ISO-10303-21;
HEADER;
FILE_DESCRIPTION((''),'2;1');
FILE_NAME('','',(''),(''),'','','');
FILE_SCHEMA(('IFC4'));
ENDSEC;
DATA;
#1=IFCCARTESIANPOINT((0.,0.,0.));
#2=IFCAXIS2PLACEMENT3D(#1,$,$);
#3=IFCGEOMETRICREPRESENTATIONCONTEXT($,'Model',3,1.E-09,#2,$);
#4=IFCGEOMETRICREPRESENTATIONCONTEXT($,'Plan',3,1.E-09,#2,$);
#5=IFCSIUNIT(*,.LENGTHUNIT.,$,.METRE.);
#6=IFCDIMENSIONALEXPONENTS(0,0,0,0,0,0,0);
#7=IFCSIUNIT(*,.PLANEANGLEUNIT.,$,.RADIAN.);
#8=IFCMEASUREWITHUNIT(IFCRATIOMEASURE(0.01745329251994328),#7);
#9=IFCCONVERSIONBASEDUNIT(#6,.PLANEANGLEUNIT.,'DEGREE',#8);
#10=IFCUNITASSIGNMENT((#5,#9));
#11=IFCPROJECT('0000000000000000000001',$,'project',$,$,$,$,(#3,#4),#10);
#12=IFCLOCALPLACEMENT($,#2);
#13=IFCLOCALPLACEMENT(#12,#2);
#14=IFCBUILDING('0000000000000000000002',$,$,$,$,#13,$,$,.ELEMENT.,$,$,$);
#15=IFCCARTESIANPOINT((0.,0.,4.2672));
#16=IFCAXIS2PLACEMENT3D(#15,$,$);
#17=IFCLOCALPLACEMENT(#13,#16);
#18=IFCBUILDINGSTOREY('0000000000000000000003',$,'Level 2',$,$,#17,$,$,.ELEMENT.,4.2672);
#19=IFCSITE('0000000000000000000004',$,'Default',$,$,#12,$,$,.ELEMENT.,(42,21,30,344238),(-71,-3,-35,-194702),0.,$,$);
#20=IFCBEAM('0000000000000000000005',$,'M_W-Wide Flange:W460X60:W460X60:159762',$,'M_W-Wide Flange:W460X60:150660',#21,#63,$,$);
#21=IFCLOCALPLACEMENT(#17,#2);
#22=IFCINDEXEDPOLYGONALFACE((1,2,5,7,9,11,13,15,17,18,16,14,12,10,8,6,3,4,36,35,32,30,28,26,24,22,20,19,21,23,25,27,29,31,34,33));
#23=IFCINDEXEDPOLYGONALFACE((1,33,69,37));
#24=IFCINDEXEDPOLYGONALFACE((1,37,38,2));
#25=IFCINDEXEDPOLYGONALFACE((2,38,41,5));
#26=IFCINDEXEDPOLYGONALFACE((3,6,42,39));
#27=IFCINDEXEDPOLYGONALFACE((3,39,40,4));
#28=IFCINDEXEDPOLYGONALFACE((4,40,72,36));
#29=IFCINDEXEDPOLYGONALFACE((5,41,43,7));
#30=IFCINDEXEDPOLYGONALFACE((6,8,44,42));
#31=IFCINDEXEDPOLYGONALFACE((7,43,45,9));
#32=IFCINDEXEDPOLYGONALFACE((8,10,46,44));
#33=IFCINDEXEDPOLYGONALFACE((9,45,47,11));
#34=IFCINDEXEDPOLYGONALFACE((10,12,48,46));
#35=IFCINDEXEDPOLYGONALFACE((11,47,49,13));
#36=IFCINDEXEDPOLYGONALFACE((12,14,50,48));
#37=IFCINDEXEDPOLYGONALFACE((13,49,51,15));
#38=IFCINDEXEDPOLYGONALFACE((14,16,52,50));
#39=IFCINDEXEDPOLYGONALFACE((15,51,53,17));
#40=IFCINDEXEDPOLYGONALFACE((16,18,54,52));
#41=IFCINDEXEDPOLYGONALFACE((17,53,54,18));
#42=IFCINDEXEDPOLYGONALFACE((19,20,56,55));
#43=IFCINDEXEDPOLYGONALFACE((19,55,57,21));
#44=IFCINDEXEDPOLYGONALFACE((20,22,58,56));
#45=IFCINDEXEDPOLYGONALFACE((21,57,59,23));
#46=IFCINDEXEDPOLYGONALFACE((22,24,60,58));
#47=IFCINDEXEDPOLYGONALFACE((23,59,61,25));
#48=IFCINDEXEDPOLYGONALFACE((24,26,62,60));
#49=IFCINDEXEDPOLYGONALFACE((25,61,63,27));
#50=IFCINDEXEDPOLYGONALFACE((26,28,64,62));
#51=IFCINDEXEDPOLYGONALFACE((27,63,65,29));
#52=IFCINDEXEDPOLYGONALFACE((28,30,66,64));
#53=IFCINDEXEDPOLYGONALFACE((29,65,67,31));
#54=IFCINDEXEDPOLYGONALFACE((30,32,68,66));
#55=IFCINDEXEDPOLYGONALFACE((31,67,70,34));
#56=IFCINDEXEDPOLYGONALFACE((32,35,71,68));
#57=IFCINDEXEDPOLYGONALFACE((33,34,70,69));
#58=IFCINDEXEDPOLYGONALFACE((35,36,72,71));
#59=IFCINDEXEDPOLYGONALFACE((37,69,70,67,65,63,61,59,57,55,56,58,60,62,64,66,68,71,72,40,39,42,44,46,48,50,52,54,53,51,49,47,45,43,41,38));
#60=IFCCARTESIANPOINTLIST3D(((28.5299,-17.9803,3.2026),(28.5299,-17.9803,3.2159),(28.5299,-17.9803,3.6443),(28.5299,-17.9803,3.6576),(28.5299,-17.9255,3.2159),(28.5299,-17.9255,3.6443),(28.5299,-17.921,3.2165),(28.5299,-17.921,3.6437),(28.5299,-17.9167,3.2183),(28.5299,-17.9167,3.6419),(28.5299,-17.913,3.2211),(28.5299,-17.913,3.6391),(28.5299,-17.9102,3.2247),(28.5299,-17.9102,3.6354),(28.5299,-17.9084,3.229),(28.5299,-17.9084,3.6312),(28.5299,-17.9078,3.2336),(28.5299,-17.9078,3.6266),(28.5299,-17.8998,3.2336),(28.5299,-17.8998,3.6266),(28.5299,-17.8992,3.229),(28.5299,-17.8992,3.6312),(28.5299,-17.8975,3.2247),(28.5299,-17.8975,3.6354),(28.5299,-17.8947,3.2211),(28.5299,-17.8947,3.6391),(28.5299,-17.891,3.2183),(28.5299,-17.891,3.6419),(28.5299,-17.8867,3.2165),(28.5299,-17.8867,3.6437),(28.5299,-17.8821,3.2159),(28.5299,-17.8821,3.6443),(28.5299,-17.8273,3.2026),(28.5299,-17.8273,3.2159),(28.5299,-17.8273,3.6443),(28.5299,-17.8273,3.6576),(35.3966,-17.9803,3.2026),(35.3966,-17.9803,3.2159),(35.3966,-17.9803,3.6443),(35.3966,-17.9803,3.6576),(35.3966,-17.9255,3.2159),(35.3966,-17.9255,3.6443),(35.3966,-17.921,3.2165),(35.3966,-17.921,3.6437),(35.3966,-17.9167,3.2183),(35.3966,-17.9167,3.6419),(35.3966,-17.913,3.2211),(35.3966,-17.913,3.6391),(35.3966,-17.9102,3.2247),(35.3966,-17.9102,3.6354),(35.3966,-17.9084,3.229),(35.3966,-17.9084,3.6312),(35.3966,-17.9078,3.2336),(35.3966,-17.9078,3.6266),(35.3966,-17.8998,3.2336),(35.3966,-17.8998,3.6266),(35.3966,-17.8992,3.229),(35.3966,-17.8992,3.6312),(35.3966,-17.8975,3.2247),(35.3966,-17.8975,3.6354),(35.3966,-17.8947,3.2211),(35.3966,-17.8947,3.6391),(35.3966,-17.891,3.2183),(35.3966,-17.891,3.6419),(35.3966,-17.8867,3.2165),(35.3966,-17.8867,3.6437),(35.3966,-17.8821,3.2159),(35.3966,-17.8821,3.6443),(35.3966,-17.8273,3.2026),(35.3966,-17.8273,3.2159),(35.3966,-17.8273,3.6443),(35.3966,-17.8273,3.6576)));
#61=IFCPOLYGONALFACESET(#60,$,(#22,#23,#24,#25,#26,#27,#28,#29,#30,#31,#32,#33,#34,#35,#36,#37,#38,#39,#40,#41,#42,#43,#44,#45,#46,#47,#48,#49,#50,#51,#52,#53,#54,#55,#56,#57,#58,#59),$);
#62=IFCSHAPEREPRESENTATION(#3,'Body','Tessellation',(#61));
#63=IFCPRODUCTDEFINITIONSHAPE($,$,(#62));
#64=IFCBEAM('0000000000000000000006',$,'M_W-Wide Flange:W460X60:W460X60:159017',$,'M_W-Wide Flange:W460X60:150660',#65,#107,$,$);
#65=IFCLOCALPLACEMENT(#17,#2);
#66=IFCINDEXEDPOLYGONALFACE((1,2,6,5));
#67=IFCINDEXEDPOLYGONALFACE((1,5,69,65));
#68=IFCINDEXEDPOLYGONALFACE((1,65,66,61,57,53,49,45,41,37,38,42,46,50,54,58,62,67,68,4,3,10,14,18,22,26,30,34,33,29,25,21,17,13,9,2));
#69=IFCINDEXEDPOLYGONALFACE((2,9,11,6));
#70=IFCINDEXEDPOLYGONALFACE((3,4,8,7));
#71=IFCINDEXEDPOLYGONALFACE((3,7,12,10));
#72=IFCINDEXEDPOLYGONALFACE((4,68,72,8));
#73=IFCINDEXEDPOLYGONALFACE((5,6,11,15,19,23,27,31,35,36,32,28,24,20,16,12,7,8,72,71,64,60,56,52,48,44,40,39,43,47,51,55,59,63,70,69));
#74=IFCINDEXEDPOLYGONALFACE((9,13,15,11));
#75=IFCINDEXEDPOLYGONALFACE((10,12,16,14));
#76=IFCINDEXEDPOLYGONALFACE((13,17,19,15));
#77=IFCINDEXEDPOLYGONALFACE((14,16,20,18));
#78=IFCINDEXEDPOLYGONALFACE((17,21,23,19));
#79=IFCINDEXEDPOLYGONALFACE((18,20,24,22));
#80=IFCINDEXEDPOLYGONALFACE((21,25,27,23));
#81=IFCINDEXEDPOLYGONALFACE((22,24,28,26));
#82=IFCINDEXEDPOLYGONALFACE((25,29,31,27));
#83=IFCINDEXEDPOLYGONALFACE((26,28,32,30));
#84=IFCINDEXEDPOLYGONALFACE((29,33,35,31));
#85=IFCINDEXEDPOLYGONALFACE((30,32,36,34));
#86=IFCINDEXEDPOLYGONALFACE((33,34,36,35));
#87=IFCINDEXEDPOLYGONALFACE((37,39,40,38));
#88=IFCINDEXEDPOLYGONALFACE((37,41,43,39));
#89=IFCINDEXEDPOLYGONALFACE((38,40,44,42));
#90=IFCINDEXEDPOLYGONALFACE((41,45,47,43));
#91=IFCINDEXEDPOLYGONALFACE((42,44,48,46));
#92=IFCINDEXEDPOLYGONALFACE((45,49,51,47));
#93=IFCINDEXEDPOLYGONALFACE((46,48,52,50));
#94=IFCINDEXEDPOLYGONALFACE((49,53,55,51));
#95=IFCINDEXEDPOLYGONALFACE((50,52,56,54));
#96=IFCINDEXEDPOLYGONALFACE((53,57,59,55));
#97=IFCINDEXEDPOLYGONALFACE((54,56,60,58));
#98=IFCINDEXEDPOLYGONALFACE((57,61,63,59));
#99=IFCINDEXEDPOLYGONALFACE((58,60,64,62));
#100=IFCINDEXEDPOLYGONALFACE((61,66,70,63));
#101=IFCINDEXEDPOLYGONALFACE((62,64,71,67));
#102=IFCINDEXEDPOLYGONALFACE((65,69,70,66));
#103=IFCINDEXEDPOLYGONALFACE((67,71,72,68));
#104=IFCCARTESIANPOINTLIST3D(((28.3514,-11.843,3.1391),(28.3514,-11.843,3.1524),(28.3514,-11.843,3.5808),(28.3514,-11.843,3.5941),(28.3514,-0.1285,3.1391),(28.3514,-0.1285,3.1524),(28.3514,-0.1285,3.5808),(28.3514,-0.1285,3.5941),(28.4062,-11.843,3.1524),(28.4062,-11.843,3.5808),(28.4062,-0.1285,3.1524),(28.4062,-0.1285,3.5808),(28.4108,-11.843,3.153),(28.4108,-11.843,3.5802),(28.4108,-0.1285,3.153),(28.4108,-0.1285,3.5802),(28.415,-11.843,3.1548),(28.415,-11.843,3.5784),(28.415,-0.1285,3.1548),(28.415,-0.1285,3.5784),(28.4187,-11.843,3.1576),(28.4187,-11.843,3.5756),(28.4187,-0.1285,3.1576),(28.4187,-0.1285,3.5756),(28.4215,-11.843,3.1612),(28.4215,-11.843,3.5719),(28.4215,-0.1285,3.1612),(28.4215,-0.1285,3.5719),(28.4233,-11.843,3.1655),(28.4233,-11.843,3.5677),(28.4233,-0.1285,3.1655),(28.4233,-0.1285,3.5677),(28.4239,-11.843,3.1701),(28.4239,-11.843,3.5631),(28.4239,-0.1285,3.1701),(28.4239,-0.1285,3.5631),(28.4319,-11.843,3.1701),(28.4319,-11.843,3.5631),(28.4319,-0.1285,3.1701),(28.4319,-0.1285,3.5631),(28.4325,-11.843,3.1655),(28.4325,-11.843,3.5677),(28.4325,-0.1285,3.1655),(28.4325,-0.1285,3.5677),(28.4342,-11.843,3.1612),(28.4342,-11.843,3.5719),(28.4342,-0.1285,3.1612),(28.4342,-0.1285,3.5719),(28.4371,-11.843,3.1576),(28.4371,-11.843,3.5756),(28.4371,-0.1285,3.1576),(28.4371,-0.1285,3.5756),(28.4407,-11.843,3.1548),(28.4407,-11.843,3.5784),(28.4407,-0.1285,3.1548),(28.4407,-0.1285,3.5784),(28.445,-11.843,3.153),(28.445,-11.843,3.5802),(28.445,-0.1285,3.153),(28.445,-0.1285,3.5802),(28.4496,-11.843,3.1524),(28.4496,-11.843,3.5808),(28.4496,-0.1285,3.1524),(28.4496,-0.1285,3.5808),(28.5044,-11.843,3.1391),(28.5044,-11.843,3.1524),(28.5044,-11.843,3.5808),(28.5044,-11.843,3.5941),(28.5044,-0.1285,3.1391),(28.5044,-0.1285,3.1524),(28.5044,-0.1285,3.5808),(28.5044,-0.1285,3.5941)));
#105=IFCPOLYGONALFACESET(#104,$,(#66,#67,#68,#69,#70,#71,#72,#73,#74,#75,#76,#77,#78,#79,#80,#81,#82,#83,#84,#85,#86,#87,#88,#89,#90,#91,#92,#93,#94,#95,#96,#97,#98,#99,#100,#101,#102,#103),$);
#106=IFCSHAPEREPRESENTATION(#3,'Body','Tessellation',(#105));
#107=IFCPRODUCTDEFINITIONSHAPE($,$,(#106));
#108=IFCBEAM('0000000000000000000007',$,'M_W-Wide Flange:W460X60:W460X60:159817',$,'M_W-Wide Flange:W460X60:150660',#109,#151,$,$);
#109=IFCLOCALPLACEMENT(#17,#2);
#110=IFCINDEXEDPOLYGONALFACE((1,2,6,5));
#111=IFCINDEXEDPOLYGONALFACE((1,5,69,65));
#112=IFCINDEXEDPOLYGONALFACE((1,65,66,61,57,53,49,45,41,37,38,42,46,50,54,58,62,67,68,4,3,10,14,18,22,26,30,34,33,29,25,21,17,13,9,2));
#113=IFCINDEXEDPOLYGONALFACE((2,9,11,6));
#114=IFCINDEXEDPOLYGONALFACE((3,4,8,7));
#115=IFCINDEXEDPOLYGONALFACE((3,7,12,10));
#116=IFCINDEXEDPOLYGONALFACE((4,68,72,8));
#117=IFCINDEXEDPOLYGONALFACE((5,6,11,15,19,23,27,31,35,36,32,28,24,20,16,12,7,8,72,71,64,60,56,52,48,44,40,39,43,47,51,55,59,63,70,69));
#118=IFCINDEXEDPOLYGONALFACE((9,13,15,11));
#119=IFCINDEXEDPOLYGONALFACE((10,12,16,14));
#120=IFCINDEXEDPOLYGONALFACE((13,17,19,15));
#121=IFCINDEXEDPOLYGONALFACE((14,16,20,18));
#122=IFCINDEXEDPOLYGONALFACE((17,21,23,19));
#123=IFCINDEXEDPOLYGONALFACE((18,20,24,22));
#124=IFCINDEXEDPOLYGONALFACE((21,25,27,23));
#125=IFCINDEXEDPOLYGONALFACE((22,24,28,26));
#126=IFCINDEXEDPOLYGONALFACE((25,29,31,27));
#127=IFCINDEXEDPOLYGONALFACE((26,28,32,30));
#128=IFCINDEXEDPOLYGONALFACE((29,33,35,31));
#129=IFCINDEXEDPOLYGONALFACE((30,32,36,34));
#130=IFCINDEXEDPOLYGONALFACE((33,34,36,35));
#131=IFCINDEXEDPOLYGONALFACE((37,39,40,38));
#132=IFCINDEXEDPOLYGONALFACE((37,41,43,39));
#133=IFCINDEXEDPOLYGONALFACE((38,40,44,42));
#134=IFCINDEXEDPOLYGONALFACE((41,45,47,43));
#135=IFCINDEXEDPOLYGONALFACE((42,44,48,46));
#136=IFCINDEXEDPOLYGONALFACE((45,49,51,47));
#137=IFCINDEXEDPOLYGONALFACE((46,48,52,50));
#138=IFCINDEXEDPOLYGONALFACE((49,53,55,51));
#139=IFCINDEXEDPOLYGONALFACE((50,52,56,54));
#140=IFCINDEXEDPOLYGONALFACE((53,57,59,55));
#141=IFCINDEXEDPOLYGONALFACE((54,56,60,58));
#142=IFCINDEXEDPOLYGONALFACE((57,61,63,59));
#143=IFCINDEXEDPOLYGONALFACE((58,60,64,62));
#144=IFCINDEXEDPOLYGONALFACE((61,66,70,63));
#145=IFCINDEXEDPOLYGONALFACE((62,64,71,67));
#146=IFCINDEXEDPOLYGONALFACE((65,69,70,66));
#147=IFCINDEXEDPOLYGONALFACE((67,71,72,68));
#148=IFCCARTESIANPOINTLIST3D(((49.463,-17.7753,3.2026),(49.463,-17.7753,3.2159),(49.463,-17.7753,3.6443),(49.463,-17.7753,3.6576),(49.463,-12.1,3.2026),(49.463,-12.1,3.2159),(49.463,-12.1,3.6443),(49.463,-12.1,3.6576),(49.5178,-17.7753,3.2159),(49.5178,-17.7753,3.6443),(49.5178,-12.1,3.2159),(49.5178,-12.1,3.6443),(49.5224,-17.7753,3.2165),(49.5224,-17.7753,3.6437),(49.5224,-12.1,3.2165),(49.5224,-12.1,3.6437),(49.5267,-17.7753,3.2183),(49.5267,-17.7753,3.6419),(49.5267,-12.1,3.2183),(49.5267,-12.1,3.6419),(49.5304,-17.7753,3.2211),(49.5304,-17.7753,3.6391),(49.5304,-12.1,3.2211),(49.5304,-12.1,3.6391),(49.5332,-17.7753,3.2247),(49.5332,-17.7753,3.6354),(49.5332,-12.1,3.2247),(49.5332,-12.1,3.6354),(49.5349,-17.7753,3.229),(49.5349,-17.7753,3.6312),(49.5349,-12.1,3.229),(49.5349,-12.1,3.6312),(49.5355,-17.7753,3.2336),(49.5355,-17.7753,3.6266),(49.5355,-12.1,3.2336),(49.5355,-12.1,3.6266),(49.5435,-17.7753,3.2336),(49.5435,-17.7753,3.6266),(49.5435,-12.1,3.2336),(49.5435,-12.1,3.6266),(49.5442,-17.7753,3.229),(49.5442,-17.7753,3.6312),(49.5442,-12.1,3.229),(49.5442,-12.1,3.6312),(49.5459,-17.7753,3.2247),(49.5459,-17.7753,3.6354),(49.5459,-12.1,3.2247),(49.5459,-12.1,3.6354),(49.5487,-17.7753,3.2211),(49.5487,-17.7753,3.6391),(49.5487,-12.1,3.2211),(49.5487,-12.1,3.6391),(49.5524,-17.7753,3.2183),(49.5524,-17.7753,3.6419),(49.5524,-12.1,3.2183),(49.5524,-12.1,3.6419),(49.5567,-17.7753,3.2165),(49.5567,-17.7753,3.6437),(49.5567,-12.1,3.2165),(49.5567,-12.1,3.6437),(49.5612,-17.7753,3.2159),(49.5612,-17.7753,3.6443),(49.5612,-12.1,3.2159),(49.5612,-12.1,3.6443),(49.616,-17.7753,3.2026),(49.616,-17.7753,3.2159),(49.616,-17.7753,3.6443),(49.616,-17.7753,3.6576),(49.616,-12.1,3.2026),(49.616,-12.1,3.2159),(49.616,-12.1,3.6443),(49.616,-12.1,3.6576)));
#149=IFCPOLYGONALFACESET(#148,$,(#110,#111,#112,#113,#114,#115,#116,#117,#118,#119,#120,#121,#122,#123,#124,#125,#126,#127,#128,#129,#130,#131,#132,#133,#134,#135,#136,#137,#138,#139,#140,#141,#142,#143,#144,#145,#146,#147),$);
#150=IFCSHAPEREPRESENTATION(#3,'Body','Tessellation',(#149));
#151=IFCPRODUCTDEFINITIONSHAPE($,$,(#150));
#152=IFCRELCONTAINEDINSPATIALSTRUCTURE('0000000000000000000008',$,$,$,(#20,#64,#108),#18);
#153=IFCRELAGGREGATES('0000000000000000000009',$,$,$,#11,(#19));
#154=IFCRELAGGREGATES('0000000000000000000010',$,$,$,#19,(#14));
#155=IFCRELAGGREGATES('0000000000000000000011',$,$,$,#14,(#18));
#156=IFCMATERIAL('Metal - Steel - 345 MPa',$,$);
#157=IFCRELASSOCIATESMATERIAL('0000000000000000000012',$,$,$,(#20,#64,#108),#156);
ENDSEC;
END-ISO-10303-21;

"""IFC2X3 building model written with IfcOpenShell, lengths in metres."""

from ifc_helpers import new_model, entity, si_unit, converted_unit, frame, frame_2d, origin, place, context, project, spatial, polyline, circle_curve, parameter, trimmed, segment, composite_curve, outline, extrude, material, element, save


model = new_model("IFC2X3")

# Units and contexts
model_context = context("Model", 3, precision=1e-09, world=origin())
plan_context = context("Plan", 3, precision=1e-09, world=origin())
ifc_project = project(units=[si_unit("LENGTHUNIT", "METRE"), converted_unit("PLANEANGLEUNIT", "DEGREE", entity("IfcRatioMeasure", 0.01745329251994328), si_unit("PLANEANGLEUNIT", "RADIAN"), dimensions=[0, 0, 0, 0, 0, 0, 0])], contexts=[model_context, plan_context])

# Site, building, storey
site_placement = place(None, origin())
site = spatial("IfcSite", under=ifc_project, at=site_placement, Name="Default", CompositionType="ELEMENT", RefLatitude=(42, 21, 30, 344238), RefLongitude=(-71, -3, -35, -194702), RefElevation=0.0)
building_placement = place(site_placement, origin())
building = spatial("IfcBuilding", under=site, at=building_placement, CompositionType="ELEMENT")
storey_placement = place(building_placement, frame((0.0, 0.0, 4.2672)))
storey = spatial("IfcBuildingStorey", under=building, at=storey_placement, Name="Level 2", CompositionType="ELEMENT", Elevation=4.2672)

# Shared definitions
ifc_material = material(Name="Metal - Steel - 345 MPa")

# Beams
beam_1_placement = place(storey_placement, frame((28.4279, -17.9038, 3.6576), z_axis=(0.0, 0.0, 1.0), x_axis=(0.0, -1.0, 0.0)))
element("IfcBeam", 1, at=beam_1_placement, inside=storey, material=ifc_material, Name="M_W-Wide Flange:W460X60:W460X60:159762", ObjectType="M_W-Wide Flange:W460X60:150660", context=model_context, shape_type="SweptSolid", body=[
    extrude(outline(composite_curve([segment(polyline([(-0.0765, -0.2142), (-0.0765, -0.2275)]), True, "CONTINUOUS"), segment(polyline([(-0.0765, -0.2275), (0.0765, -0.2275)]), True, "CONTINUOUS"), segment(polyline([(0.0765, -0.2275), (0.0765, -0.2142)]), True, "CONTINUOUS"), segment(polyline([(0.0765, -0.2142), (0.0217, -0.2142)]), True, "CONTINUOUS"), segment(trimmed(circle_curve(frame_2d((0.0217, -0.1965), x_axis=(0.0, -1.0)), 0.0177), [parameter(270.0)], [parameter(360.0)], True, "PARAMETER"), False, "CONTINUOUS"), segment(polyline([(0.004, -0.1965), (0.004, 0.1965)]), True, "CONTINUOUS"), segment(trimmed(circle_curve(frame_2d((0.0217, 0.1965), x_axis=(-1.0, 0.0)), 0.0177), [parameter(270.0)], [parameter(360.0)], True, "PARAMETER"), False, "CONTINUOUS"), segment(polyline([(0.0217, 0.2142), (0.0765, 0.2142)]), True, "CONTINUOUS"), segment(polyline([(0.0765, 0.2142), (0.0765, 0.2275)]), True, "CONTINUOUS"), segment(polyline([(0.0765, 0.2275), (-0.0765, 0.2275)]), True, "CONTINUOUS"), segment(polyline([(-0.0765, 0.2275), (-0.0765, 0.2142)]), True, "CONTINUOUS"), segment(polyline([(-0.0765, 0.2142), (-0.0217, 0.2142)]), True, "CONTINUOUS"), segment(trimmed(circle_curve(frame_2d((-0.0217, 0.1965), x_axis=(0.0, 1.0)), 0.0177), [parameter(270.0)], [parameter(360.0)], True, "PARAMETER"), False, "CONTINUOUS"), segment(polyline([(-0.004, 0.1965), (-0.004, -0.1965)]), True, "CONTINUOUS"), segment(trimmed(circle_curve(frame_2d((-0.0217, -0.1965), x_axis=(1.0, 0.0)), 0.0177), [parameter(270.0)], [parameter(0.0)], True, "PARAMETER"), False, "CONTINUOUS"), segment(polyline([(-0.0217, -0.2142), (-0.0765, -0.2142)]), True, "CONTINUOUS")], self_intersect=False)), frame((0.0, 0.102, -0.2275), z_axis=(0.0, -1.0, 0.0), x_axis=(1.0, 0.0, 0.0)), (0.0, 0.0, -1.0), 6.8668),
])
beam_2_placement = place(storey_placement, frame((28.4279, 0.0, 3.6576), z_axis=(0.0, 0.0, 1.0), x_axis=(-1.0, 0.0, 0.0)))
element("IfcBeam", 2, at=beam_2_placement, inside=storey, material=ifc_material, Name="M_W-Wide Flange:W460X60:W460X60:159017", ObjectType="M_W-Wide Flange:W460X60:150660", context=model_context, shape_type="SweptSolid", body=[
    extrude(outline(composite_curve([segment(polyline([(0.2142, -0.0765), (0.2275, -0.0765)]), True, "CONTINUOUS"), segment(polyline([(0.2275, -0.0765), (0.2275, 0.0765)]), True, "CONTINUOUS"), segment(polyline([(0.2275, 0.0765), (0.2142, 0.0765)]), True, "CONTINUOUS"), segment(polyline([(0.2142, 0.0765), (0.2142, 0.0217)]), True, "CONTINUOUS"), segment(trimmed(circle_curve(frame_2d((0.1965, 0.0217), x_axis=(0.0, 1.0)), 0.0177), [parameter(180.0)], [parameter(270.0)], True, "PARAMETER"), False, "CONTINUOUS"), segment(polyline([(0.1965, 0.004), (-0.1965, 0.004)]), True, "CONTINUOUS"), segment(trimmed(circle_curve(frame_2d((-0.1965, 0.0217), x_axis=(0.0, 1.0)), 0.0177), [parameter(90.0)], [parameter(180.0)], True, "PARAMETER"), False, "CONTINUOUS"), segment(polyline([(-0.2142, 0.0217), (-0.2142, 0.0765)]), True, "CONTINUOUS"), segment(polyline([(-0.2142, 0.0765), (-0.2275, 0.0765)]), True, "CONTINUOUS"), segment(polyline([(-0.2275, 0.0765), (-0.2275, -0.0765)]), True, "CONTINUOUS"), segment(polyline([(-0.2275, -0.0765), (-0.2142, -0.0765)]), True, "CONTINUOUS"), segment(polyline([(-0.2142, -0.0765), (-0.2142, -0.0217)]), True, "CONTINUOUS"), segment(trimmed(circle_curve(frame_2d((-0.1965, -0.0217), x_axis=(0.0, 1.0)), 0.0177), [parameter(360.0)], [parameter(90.0)], True, "PARAMETER"), False, "CONTINUOUS"), segment(polyline([(-0.1965, -0.004), (0.1965, -0.004)]), True, "CONTINUOUS"), segment(trimmed(circle_curve(frame_2d((0.1965, -0.0217), x_axis=(0.0, 1.0)), 0.0177), [parameter(270.0)], [parameter(0.0)], True, "PARAMETER"), False, "CONTINUOUS"), segment(polyline([(0.2142, -0.0217), (0.2142, -0.0765)]), True, "CONTINUOUS")], self_intersect=False)), frame((0.0, 11.843, -0.291), z_axis=(0.0, -1.0, 0.0), x_axis=(0.0, 0.0, -1.0)), (0.0, 0.0, 1.0), 11.7145),
])
beam_3_placement = place(storey_placement, frame((49.5395, -11.9715, 3.6576), z_axis=(0.0, 0.0, 1.0), x_axis=(-1.0, 0.0, 0.0)))
element("IfcBeam", 3, at=beam_3_placement, inside=storey, material=ifc_material, Name="M_W-Wide Flange:W460X60:W460X60:159817", ObjectType="M_W-Wide Flange:W460X60:150660", context=model_context, shape_type="SweptSolid", body=[
    extrude(outline(composite_curve([segment(polyline([(0.2142, -0.0765), (0.2275, -0.0765)]), True, "CONTINUOUS"), segment(polyline([(0.2275, -0.0765), (0.2275, 0.0765)]), True, "CONTINUOUS"), segment(polyline([(0.2275, 0.0765), (0.2142, 0.0765)]), True, "CONTINUOUS"), segment(polyline([(0.2142, 0.0765), (0.2142, 0.0217)]), True, "CONTINUOUS"), segment(trimmed(circle_curve(frame_2d((0.1965, 0.0217), x_axis=(1.0, 0.0)), 0.0177), [parameter(270.0)], [parameter(360.0)], True, "PARAMETER"), False, "CONTINUOUS"), segment(polyline([(0.1965, 0.004), (-0.1965, 0.004)]), True, "CONTINUOUS"), segment(trimmed(circle_curve(frame_2d((-0.1965, 0.0217), x_axis=(0.0, -1.0)), 0.0177), [parameter(270.0)], [parameter(360.0)], True, "PARAMETER"), False, "CONTINUOUS"), segment(polyline([(-0.2142, 0.0217), (-0.2142, 0.0765)]), True, "CONTINUOUS"), segment(polyline([(-0.2142, 0.0765), (-0.2275, 0.0765)]), True, "CONTINUOUS"), segment(polyline([(-0.2275, 0.0765), (-0.2275, -0.0765)]), True, "CONTINUOUS"), segment(polyline([(-0.2275, -0.0765), (-0.2142, -0.0765)]), True, "CONTINUOUS"), segment(polyline([(-0.2142, -0.0765), (-0.2142, -0.0217)]), True, "CONTINUOUS"), segment(trimmed(circle_curve(frame_2d((-0.1965, -0.0217), x_axis=(-1.0, 0.0)), 0.0177), [parameter(270.0)], [parameter(360.0)], True, "PARAMETER"), False, "CONTINUOUS"), segment(polyline([(-0.1965, -0.004), (0.1965, -0.004)]), True, "CONTINUOUS"), segment(trimmed(circle_curve(frame_2d((0.1965, -0.0217), x_axis=(0.0, 1.0)), 0.0177), [parameter(270.0)], [parameter(0.0)], True, "PARAMETER"), False, "CONTINUOUS"), segment(polyline([(0.2142, -0.0217), (0.2142, -0.0765)]), True, "CONTINUOUS")], self_intersect=False)), frame((0.0, 5.8039, -0.2275), z_axis=(0.0, -1.0, 0.0), x_axis=(0.0, 0.0, -1.0)), (0.0, 0.0, 1.0), 5.6754),
])

save(model, "model.ifc")
